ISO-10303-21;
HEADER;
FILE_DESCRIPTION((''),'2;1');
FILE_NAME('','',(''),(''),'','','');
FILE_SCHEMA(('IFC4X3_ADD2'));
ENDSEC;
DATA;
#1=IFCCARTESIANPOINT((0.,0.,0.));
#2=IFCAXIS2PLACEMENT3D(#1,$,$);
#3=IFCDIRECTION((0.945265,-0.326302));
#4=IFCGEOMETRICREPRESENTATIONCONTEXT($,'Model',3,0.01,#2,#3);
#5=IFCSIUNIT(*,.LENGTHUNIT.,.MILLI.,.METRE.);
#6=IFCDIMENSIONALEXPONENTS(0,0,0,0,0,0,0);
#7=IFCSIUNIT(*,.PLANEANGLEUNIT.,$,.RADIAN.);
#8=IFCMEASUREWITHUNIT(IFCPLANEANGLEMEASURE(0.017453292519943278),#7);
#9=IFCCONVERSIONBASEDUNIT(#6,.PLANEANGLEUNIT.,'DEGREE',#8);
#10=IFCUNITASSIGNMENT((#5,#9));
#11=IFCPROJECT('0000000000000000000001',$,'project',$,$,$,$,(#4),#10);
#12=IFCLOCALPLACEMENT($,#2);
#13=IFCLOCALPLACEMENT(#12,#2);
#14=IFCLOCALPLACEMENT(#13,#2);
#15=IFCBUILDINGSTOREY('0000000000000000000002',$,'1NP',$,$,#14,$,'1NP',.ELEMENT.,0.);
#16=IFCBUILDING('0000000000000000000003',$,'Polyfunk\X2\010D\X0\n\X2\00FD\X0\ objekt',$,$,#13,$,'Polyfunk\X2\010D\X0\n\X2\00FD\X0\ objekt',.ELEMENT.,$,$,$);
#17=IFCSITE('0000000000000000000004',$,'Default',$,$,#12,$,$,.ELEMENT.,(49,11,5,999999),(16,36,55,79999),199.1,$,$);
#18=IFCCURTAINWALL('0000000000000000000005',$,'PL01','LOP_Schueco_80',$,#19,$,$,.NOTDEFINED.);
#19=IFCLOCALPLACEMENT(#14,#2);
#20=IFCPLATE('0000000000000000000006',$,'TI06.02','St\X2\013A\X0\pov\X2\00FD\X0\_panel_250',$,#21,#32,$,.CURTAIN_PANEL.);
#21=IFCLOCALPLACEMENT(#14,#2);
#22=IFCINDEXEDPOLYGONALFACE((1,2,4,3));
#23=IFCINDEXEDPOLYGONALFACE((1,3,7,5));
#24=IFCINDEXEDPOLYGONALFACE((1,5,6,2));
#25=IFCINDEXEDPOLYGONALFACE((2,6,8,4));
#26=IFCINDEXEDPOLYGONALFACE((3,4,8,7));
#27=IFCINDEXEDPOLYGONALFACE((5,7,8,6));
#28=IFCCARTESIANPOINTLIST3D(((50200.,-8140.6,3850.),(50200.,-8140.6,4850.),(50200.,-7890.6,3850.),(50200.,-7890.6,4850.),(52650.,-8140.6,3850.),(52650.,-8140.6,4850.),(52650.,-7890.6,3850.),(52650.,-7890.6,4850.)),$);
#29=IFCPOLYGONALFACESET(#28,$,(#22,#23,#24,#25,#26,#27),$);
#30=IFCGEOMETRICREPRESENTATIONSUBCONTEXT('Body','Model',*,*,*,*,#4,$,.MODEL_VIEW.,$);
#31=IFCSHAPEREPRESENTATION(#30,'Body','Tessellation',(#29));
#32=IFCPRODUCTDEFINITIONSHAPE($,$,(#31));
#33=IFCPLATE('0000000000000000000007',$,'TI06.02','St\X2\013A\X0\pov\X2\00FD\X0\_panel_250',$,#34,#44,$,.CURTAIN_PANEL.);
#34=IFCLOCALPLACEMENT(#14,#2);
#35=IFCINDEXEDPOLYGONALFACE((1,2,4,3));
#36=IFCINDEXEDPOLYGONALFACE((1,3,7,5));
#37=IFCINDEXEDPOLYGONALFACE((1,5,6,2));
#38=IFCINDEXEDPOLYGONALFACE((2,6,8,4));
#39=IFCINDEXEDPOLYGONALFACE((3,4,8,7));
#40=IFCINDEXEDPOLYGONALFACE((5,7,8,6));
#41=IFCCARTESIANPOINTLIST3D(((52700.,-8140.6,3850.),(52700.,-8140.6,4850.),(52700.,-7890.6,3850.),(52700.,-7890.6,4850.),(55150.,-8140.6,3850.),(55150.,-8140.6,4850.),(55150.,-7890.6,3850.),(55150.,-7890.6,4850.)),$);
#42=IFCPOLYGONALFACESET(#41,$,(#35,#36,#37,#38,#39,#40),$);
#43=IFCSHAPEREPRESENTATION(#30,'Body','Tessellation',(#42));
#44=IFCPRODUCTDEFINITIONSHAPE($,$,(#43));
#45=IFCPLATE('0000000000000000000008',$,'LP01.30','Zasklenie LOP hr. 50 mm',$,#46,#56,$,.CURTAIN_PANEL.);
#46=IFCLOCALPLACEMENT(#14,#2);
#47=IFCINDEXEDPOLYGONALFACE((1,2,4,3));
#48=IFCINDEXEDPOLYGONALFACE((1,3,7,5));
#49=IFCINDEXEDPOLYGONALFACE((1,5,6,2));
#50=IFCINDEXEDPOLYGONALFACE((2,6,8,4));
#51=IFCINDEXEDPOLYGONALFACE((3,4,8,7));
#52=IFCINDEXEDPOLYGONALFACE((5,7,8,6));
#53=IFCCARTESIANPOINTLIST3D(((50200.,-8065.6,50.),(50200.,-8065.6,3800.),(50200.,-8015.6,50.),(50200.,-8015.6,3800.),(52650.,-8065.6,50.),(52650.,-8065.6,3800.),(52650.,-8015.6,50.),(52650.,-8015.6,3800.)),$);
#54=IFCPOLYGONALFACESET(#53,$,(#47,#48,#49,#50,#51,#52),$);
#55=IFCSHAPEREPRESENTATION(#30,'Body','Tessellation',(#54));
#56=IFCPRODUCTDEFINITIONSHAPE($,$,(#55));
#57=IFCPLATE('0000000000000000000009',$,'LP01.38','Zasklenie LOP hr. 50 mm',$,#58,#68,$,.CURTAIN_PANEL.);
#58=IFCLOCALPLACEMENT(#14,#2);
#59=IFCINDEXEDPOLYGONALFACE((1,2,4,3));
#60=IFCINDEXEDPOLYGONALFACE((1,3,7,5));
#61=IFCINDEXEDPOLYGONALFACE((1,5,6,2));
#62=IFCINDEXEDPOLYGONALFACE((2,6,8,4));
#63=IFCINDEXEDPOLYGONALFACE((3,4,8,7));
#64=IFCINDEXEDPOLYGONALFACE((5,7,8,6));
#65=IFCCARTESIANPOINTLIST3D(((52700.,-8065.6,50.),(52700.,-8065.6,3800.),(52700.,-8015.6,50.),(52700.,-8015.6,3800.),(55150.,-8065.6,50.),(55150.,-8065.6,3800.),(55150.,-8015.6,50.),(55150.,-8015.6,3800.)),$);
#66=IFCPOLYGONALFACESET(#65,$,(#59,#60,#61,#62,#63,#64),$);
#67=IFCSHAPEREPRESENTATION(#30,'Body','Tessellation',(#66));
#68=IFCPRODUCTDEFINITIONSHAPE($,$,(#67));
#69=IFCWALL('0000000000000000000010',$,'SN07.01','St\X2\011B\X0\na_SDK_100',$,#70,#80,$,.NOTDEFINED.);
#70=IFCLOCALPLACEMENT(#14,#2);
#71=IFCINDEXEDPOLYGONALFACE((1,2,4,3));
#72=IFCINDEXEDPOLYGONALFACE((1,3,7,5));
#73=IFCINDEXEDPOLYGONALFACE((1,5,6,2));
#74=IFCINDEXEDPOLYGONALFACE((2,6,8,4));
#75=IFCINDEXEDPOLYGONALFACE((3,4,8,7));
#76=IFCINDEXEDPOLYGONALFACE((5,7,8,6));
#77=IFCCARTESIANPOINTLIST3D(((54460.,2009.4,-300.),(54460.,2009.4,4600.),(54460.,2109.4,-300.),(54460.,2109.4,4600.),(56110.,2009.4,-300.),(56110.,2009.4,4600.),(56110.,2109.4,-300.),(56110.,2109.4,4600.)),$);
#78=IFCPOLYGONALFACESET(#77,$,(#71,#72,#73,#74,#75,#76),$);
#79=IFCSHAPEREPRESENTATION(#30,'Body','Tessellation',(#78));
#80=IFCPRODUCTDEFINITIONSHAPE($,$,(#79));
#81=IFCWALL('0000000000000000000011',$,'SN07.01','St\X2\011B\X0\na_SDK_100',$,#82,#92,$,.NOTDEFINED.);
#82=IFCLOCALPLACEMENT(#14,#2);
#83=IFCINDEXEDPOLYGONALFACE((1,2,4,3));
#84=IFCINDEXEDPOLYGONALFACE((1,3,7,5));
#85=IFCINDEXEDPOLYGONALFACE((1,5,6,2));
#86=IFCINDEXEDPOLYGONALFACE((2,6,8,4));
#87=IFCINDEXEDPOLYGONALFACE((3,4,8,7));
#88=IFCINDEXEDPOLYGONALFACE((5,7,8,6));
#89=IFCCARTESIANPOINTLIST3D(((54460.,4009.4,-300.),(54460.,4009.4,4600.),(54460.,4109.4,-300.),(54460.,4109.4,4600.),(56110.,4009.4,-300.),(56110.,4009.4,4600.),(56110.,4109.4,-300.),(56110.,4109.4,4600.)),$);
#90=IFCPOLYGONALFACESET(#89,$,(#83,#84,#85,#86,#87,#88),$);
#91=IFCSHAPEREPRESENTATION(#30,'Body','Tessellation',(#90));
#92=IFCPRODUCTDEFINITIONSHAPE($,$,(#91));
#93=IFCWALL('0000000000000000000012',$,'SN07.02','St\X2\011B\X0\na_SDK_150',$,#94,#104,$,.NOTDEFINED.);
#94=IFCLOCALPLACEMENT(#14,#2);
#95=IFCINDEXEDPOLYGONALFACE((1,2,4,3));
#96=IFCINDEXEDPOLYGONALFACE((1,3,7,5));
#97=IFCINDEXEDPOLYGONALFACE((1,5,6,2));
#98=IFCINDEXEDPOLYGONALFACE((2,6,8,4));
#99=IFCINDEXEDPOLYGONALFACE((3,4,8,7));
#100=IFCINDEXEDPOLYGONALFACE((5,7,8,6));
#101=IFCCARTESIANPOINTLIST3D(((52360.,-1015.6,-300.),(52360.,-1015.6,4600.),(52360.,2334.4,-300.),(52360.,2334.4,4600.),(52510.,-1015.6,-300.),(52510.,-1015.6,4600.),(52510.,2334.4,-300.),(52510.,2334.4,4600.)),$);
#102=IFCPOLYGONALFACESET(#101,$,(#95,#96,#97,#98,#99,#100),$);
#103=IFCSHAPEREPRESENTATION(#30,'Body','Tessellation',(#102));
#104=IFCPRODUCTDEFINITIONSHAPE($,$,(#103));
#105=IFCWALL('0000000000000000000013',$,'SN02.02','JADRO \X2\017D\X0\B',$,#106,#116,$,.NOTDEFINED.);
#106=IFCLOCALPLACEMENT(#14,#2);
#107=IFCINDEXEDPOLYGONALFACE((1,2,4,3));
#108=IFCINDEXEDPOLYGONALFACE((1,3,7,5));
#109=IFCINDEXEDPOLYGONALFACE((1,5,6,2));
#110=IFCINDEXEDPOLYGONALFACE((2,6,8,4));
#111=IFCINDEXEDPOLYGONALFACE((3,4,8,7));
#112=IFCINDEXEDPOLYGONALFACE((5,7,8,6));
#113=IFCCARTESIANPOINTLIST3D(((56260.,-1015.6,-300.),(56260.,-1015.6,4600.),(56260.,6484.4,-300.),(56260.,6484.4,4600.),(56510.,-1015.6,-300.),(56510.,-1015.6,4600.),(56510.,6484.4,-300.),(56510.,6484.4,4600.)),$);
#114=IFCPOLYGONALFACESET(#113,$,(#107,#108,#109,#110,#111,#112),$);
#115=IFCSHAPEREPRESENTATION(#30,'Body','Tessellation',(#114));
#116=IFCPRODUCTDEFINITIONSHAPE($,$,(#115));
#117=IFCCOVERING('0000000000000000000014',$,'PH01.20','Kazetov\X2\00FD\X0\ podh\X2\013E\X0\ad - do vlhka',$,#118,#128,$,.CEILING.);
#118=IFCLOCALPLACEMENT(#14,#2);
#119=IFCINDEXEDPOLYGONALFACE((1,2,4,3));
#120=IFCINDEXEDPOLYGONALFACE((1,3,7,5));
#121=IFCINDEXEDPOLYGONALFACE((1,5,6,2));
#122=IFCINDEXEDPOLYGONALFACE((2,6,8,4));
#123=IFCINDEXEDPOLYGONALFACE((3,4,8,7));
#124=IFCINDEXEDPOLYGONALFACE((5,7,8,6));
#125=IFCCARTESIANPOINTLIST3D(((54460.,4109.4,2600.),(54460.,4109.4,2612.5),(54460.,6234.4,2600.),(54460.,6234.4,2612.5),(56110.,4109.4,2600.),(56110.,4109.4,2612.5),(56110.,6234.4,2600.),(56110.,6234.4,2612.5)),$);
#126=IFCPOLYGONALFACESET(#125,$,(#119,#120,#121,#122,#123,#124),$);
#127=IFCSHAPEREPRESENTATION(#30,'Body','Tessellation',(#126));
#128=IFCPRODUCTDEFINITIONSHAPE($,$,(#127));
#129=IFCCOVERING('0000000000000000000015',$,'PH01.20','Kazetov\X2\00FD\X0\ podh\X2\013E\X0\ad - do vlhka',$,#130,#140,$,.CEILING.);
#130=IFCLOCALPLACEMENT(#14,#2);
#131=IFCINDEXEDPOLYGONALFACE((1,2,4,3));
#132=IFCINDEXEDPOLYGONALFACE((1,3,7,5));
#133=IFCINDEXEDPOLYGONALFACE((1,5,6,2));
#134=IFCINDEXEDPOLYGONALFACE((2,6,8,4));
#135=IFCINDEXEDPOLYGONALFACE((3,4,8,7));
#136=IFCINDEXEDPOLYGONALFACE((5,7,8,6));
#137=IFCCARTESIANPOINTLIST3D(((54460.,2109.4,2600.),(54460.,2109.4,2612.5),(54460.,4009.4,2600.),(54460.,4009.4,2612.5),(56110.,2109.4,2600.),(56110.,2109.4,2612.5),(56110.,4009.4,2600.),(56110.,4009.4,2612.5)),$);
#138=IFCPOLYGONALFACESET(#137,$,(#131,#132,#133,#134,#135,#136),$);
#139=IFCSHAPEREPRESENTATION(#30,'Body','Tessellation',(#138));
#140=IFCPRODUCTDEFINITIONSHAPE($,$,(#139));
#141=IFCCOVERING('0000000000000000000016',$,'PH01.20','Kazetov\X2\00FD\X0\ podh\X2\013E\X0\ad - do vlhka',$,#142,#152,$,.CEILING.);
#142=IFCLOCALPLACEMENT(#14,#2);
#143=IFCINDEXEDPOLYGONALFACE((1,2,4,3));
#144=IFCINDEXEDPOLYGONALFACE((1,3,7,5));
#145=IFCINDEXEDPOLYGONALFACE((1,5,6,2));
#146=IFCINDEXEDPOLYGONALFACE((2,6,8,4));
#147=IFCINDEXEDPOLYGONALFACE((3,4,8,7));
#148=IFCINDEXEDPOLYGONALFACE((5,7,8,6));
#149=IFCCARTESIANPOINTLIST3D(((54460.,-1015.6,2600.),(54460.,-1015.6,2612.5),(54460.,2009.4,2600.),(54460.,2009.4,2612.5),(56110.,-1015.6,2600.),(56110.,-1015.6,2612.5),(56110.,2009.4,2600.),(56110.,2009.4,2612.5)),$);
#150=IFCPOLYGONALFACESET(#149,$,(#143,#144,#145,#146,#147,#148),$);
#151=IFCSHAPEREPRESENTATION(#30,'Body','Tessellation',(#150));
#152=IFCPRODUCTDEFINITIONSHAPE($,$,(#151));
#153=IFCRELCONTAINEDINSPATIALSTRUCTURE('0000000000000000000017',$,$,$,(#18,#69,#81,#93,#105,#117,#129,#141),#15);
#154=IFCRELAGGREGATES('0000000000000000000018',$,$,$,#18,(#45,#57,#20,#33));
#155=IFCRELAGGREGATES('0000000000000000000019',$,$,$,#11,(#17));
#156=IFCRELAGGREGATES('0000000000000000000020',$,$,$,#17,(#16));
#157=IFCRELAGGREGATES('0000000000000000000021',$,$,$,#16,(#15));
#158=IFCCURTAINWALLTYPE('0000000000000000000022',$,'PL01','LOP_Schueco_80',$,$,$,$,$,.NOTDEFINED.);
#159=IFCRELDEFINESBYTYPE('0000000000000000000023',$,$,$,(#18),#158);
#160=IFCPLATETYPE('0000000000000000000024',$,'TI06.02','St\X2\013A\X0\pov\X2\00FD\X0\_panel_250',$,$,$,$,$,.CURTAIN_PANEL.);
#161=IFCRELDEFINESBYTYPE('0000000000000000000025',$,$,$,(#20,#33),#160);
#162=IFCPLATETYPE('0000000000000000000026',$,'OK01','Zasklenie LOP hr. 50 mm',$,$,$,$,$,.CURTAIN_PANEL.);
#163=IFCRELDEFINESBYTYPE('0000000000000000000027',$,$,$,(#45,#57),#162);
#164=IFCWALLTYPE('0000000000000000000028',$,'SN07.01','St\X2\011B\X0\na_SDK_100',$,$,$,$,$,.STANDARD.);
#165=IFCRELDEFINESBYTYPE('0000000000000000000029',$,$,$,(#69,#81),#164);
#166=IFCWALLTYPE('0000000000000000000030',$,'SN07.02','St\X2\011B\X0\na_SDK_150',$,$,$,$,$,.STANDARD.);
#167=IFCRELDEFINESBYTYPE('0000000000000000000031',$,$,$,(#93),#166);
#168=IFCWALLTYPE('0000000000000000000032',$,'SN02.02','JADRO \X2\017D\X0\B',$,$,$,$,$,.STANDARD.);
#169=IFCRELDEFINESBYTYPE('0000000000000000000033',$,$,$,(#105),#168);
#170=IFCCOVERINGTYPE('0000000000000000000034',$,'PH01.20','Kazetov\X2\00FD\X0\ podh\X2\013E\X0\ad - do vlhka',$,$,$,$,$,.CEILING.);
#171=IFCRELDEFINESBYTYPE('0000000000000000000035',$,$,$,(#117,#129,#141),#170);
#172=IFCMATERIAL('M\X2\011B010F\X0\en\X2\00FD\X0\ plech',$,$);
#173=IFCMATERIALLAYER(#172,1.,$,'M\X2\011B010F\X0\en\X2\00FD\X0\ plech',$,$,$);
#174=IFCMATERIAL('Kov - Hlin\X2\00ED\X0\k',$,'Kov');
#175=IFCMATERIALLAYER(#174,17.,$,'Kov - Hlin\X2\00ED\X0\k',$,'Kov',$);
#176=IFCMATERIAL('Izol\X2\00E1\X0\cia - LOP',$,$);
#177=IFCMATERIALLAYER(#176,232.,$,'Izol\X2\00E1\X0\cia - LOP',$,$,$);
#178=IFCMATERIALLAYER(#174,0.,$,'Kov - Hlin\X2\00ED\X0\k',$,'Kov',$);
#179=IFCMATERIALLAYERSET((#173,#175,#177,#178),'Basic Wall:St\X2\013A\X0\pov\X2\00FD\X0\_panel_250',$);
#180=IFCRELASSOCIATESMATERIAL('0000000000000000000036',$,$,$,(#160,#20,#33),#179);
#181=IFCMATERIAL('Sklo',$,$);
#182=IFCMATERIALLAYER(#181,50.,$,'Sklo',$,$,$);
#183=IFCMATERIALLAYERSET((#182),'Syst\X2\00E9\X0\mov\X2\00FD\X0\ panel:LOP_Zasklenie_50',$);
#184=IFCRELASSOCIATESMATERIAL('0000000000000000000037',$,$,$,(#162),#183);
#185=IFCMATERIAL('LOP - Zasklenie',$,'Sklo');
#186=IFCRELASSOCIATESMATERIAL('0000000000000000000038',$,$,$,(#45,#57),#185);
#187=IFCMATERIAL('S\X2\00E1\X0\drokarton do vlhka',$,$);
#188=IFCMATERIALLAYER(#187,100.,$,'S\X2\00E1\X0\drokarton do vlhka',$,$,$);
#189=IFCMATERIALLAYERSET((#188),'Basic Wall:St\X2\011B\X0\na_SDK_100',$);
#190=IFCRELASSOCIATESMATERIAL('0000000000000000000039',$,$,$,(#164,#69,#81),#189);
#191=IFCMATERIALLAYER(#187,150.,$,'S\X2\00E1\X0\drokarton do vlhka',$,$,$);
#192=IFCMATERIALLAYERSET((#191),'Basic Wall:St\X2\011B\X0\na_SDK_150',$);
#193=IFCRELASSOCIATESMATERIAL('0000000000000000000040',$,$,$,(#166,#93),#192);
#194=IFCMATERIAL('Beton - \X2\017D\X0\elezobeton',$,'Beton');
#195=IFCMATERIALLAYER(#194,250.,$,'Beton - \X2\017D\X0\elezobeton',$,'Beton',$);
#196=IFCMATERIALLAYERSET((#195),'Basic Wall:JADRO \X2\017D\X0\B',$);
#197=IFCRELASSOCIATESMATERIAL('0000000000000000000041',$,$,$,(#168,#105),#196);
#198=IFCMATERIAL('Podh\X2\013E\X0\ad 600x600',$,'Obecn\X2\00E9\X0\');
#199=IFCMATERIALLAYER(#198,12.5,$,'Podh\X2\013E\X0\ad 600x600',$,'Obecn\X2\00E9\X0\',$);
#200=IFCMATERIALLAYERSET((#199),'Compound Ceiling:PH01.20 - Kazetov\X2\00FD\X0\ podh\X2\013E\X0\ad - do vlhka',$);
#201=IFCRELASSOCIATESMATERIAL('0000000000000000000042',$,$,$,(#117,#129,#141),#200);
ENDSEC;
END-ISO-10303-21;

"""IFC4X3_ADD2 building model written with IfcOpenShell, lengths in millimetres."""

from ifc_helpers import new_model, entity, si_unit, converted_unit, direction, frame, frame_2d, origin, origin_2d_with_axis, place, context, subcontext, project, spatial, polyline, rectangle, extrude, clip, bounded_halfspace, source, transform, mapped, material, layer, layer_set, layer_usage, type_object, type_shapes, element, aggregate, save


model = new_model("IFC4X3_ADD2")

# Units and contexts
model_context = context("Model", 3, precision=0.01, world=origin(), true_north=direction((0.945265, -0.326302)))
body_context = subcontext(model_context, "Body", "Model", "MODEL_VIEW")
ifc_project = project(units=[si_unit("LENGTHUNIT", "METRE", prefix="MILLI"), converted_unit("PLANEANGLEUNIT", "DEGREE", entity("IfcPlaneAngleMeasure", 0.017453292519943278), si_unit("PLANEANGLEUNIT", "RADIAN"), dimensions=[0, 0, 0, 0, 0, 0, 0])], contexts=[model_context])

# Site, building, storey
site_placement = place(None, origin())
site = spatial("IfcSite", under=ifc_project, at=site_placement, Name="Default", CompositionType="ELEMENT", RefLatitude=(49, 11, 5, 999999), RefLongitude=(16, 36, 55, 79999), RefElevation=199.1)
building_placement = place(site_placement, origin())
building = spatial("IfcBuilding", under=site, at=building_placement, Name="Polyfunkčný objekt", LongName="Polyfunkčný objekt", CompositionType="ELEMENT")
storey_placement = place(building_placement, origin())
storey = spatial("IfcBuildingStorey", under=building, at=storey_placement, Name="1NP", LongName="1NP", CompositionType="ELEMENT", Elevation=0.0)

# Curtain wall, plates
curtain_wall_type = type_object("IfcCurtainWallType", Name="PL01", Description="LOP_Schueco_80", PredefinedType="NOTDEFINED")
curtain_wall_placement = place(storey_placement, origin())
curtain_wall = element("IfcCurtainWall", 1, at=curtain_wall_placement, inside=storey, type_object=curtain_wall_type, Name="PL01", Description="LOP_Schueco_80", PredefinedType="NOTDEFINED")
ifc_material_1 = material(Name="Měďený plech")
ifc_layer_1 = layer(ifc_material_1, 1.0, Name="Měďený plech")
ifc_material_2 = material(Name="Kov - Hliník", Category="Kov")
ifc_layer_2 = layer(ifc_material_2, 17.0, Name="Kov - Hliník", Category="Kov")
ifc_material_3 = material(Name="Izolácia - LOP")
ifc_layer_3 = layer(ifc_material_3, 232.0, Name="Izolácia - LOP")
ifc_layer_4 = layer(ifc_material_2, 0.0, Name="Kov - Hliník", Category="Kov")
ifc_layer_set_1 = layer_set([ifc_layer_1, ifc_layer_2, ifc_layer_3, ifc_layer_4], Name="Basic Wall:Stĺpový_panel_250")
ifc_layer_usage_1 = layer_usage(ifc_layer_set_1, "AXIS2", "POSITIVE", -125.0)
plate_type_1 = type_object("IfcPlateType", Name="TI06.02", Description="Stĺpový_panel_250", PredefinedType="CURTAIN_PANEL", material=ifc_layer_set_1)
plate_1_placement = place(storey_placement, frame((50200.0, -8015.6, 3850.0)))
plate_1 = element("IfcPlate", 2, at=plate_1_placement, type_object=plate_type_1, material=ifc_layer_usage_1, Name="TI06.02", Description="Stĺpový_panel_250", PredefinedType="CURTAIN_PANEL", context=body_context, shape_type="SweptSolid", body=[
    extrude(rectangle(XDim=250.0, YDim=2450.0, at=origin_2d_with_axis()), frame((1225.0, 0.0, 0.0), z_axis=(0.0, 0.0, 1.0), x_axis=(0.0, 1.0, 0.0)), (0.0, 0.0, 1.0), 1000.0),
])
ifc_layer_usage_2 = layer_usage(ifc_layer_set_1, "AXIS2", "POSITIVE", -125.0)
plate_2_placement = place(storey_placement, frame((52700.0, -8015.6, 3850.0)))
plate_2 = element("IfcPlate", 3, at=plate_2_placement, type_object=plate_type_1, material=ifc_layer_usage_2, Name="TI06.02", Description="Stĺpový_panel_250", PredefinedType="CURTAIN_PANEL", context=body_context, shape_type="SweptSolid", body=[
    extrude(rectangle(XDim=250.0, YDim=2450.0, at=frame_2d((0.0, 0.0), x_axis=(1.0, 0.0))), frame((1225.0, 0.0, 0.0), z_axis=(0.0, 0.0, 1.0), x_axis=(0.0, 1.0, 0.0)), (0.0, 0.0, 1.0), 1000.0),
])
ifc_material_4 = material(Name="LOP - Zasklenie", Category="Sklo")
ifc_material_5 = material(Name="Sklo")
ifc_layer_5 = layer(ifc_material_5, 50.0, Name="Sklo")
ifc_layer_set_2 = layer_set([ifc_layer_5], Name="Systémový panel:LOP_Zasklenie_50")
plate_type_2 = type_object("IfcPlateType", Name="OK01", Description="Zasklenie LOP hr. 50 mm", PredefinedType="CURTAIN_PANEL", material=ifc_layer_set_2)
shared_shape_1 = source(origin(), body_context, "Body", "SweptSolid", [
    extrude(rectangle(XDim=3750.0, YDim=2450.0, at=frame_2d((-331.2, 0.0), x_axis=(1.0, 0.0))), frame((0.0, -50.0, 2206.2), z_axis=(0.0, 1.0, 0.0), x_axis=(0.0, 0.0, 1.0)), (0.0, 0.0, 1.0), 50.0),
])
type_shapes(plate_type_2, [shared_shape_1])
plate_3_placement = place(curtain_wall_placement, frame((51425.0, -8015.6, 50.0)))
plate_3 = element("IfcPlate", 4, at=plate_3_placement, type_object=plate_type_2, material=ifc_material_4, Name="LP01.30", Description="Zasklenie LOP hr. 50 mm", PredefinedType="CURTAIN_PANEL", context=body_context, shape_type="MappedRepresentation", body=[
    mapped(shared_shape_1, transform((0.0, 0.0, 0.0), scale=1.0)),
])
plate_4_placement = place(curtain_wall_placement, frame((53925.0, -8015.6, 50.0)))
plate_4 = element("IfcPlate", 5, at=plate_4_placement, type_object=plate_type_2, material=ifc_material_4, Name="LP01.38", Description="Zasklenie LOP hr. 50 mm", PredefinedType="CURTAIN_PANEL", context=body_context, shape_type="MappedRepresentation", body=[
    mapped(shared_shape_1, transform((0.0, 0.0, 0.0), scale=1.0)),
])
aggregate(curtain_wall, [plate_3, plate_4, plate_1, plate_2])

# Walls
ifc_material_6 = material(Name="Sádrokarton do vlhka")
ifc_layer_6 = layer(ifc_material_6, 100.0, Name="Sádrokarton do vlhka")
ifc_layer_set_3 = layer_set([ifc_layer_6], Name="Basic Wall:Stěna_SDK_100")
wall_type_1 = type_object("IfcWallType", Name="SN07.01", Description="Stěna_SDK_100", PredefinedType="STANDARD", material=ifc_layer_set_3)
wall_1_placement = place(storey_placement, frame((54460.0, 2059.4, -300.0)))
element("IfcWall", 6, at=wall_1_placement, inside=storey, type_object=wall_type_1, material=ifc_layer_set_3, Name="SN07.01", Description="Stěna_SDK_100", PredefinedType="NOTDEFINED", context=body_context, shape_type="Clipping", body=[
    clip(clip(extrude(rectangle(XDim=1650.0, YDim=100.0, at=frame_2d((825.0, 0.0), x_axis=(-1.0, 0.0))), origin(), (0.0, 0.0, 1.0), 4900.0), bounded_halfspace(frame((0.0, -50.0, 4900.0), z_axis=(0.0, 0.0, -1.0), x_axis=(1.0, 0.0, 0.0)), True, frame((0.0, -50.0, 4900.0)), polyline([(0.0, 0.0), (1650.0, 0.0), (1650.0, 100.0), (0.0, 100.0), (0.0, 0.0)]))), bounded_halfspace(frame((1650.0, -50.0, 0.0), z_axis=(0.0, 0.0, 1.0), x_axis=(0.0, 1.0, 0.0)), True, frame((1650.0, -50.0, 0.0)), polyline([(0.0, 0.0), (0.0, 100.0), (-1650.0, 100.0), (-1650.0, 0.0), (0.0, 0.0)]))),
])
wall_2_placement = place(storey_placement, frame((54460.0, 4059.4, -300.0)))
element("IfcWall", 7, at=wall_2_placement, inside=storey, type_object=wall_type_1, material=ifc_layer_set_3, Name="SN07.01", Description="Stěna_SDK_100", PredefinedType="NOTDEFINED", context=body_context, shape_type="Clipping", body=[
    clip(clip(extrude(rectangle(XDim=1650.0, YDim=100.0, at=frame_2d((825.0, 0.0), x_axis=(-1.0, 0.0))), origin(), (0.0, 0.0, 1.0), 4900.0), bounded_halfspace(frame((0.0, -50.0, 4900.0), z_axis=(0.0, 0.0, -1.0), x_axis=(1.0, 0.0, 0.0)), True, frame((0.0, -50.0, 4900.0)), polyline([(0.0, 0.0), (1650.0, 0.0), (1650.0, 100.0), (0.0, 100.0), (0.0, 0.0)]))), bounded_halfspace(frame((1650.0, -50.0, 0.0), z_axis=(0.0, 0.0, 1.0), x_axis=(0.0, 1.0, 0.0)), True, frame((1650.0, -50.0, 0.0)), polyline([(0.0, 0.0), (0.0, 100.0), (-1650.0, 100.0), (-1650.0, 0.0), (0.0, 0.0)]))),
])
ifc_layer_7 = layer(ifc_material_6, 150.0, Name="Sádrokarton do vlhka")
ifc_layer_set_4 = layer_set([ifc_layer_7], Name="Basic Wall:Stěna_SDK_150")
wall_type_2 = type_object("IfcWallType", Name="SN07.02", Description="Stěna_SDK_150", PredefinedType="STANDARD", material=ifc_layer_set_4)
wall_3_placement = place(storey_placement, frame((52435.0, 2334.4, -300.0), z_axis=(0.0, 0.0, 1.0), x_axis=(0.0, -1.0, 0.0)))
element("IfcWall", 8, at=wall_3_placement, inside=storey, type_object=wall_type_2, material=ifc_layer_set_4, Name="SN07.02", Description="Stěna_SDK_150", PredefinedType="NOTDEFINED", context=body_context, shape_type="Clipping", body=[
    clip(clip(extrude(rectangle(XDim=3350.0, YDim=150.0, at=frame_2d((1675.0, 0.0), x_axis=(-1.0, 0.0))), origin(), (0.0, 0.0, 1.0), 4900.0), bounded_halfspace(frame((3350.0, -75.0, 0.0), z_axis=(0.0, 0.0, 1.0), x_axis=(-1.0, 0.0, 0.0)), True, frame((3350.0, -75.0, 0.0)), polyline([(0.0, 0.0), (0.0, 150.0), (-3350.0, 150.0), (-3350.0, 0.0), (0.0, 0.0)]))), bounded_halfspace(frame((0.0, -75.0, 4900.0), z_axis=(0.0, 0.0, -1.0), x_axis=(0.0, 1.0, 0.0)), True, frame((0.0, -75.0, 4900.0)), polyline([(0.0, 0.0), (3350.0, 0.0), (3350.0, 150.0), (0.0, 150.0), (0.0, 0.0)]))),
])
ifc_material_7 = material(Name="Beton - Železobeton", Category="Beton")
ifc_layer_8 = layer(ifc_material_7, 250.0, Name="Beton - Železobeton", Category="Beton")
ifc_layer_set_5 = layer_set([ifc_layer_8], Name="Basic Wall:JADRO ŽB")
wall_type_3 = type_object("IfcWallType", Name="SN02.02", Description="JADRO ŽB", PredefinedType="STANDARD", material=ifc_layer_set_5)
wall_4_placement = place(storey_placement, frame((56385.0, -1015.6, -300.0), z_axis=(0.0, 0.0, 1.0), x_axis=(0.0, 1.0, 0.0)))
element("IfcWall", 9, at=wall_4_placement, inside=storey, type_object=wall_type_3, material=ifc_layer_set_5, Name="SN02.02", Description="JADRO ŽB", PredefinedType="NOTDEFINED", context=body_context, shape_type="Clipping", body=[
    clip(clip(extrude(rectangle(XDim=7500.0, YDim=250.0, at=frame_2d((3750.0, 0.0), x_axis=(-1.0, 0.0))), origin(), (0.0, 0.0, 1.0), 4900.0), bounded_halfspace(frame((0.0, -125.0, 4900.0), z_axis=(0.0, 0.0, -1.0), x_axis=(0.0, -1.0, 0.0)), True, frame((0.0, -125.0, 4900.0)), polyline([(0.0, 0.0), (7500.0, 0.0), (7500.0, 250.0), (7250.0, 250.0), (0.0, 250.0), (0.0, 0.0)]))), bounded_halfspace(frame((0.0, -125.0, 0.0)), True, frame((0.0, -125.0, 0.0)), polyline([(0.0, 0.0), (7110.0, 0.0), (7500.0, 0.0), (7500.0, 250.0), (7250.0, 250.0), (0.0, 250.0), (0.0, 0.0)]))),
])

# Shared definitions
ifc_material_8 = material(Name="Podhľad 600x600", Category="Obecné")

# Coverings
ifc_layer_9 = layer(ifc_material_8, 12.5, Name="Podhľad 600x600", Category="Obecné")
ifc_layer_set_6 = layer_set([ifc_layer_9], Name="Compound Ceiling:PH01.20 - Kazetový podhľad - do vlhka")
ifc_layer_usage_3 = layer_usage(ifc_layer_set_6, "AXIS3", "NEGATIVE", 0.0)
covering_type_1 = type_object("IfcCoveringType", Name="PH01.20", Description="Kazetový podhľad - do vlhka", PredefinedType="CEILING")
covering_1_placement = place(storey_placement, frame((54460.0, 4109.4, 2600.0)))
element("IfcCovering", 10, at=covering_1_placement, inside=storey, type_object=covering_type_1, material=ifc_layer_usage_3, Name="PH01.20", Description="Kazetový podhľad - do vlhka", PredefinedType="CEILING", context=body_context, shape_type="SweptSolid", body=[
    extrude(rectangle(XDim=2125.0, YDim=1650.0, at=frame_2d((0.0, 0.0), x_axis=(1.0, 0.0))), frame((825.0, 1062.5, 0.0), z_axis=(0.0, 0.0, 1.0), x_axis=(0.0, -1.0, 0.0)), (0.0, 0.0, 1.0), 12.5),
])
ifc_layer_usage_4 = layer_usage(ifc_layer_set_6, "AXIS3", "NEGATIVE", 0.0)
covering_2_placement = place(storey_placement, frame((54460.0, 2109.4, 2600.0)))
element("IfcCovering", 11, at=covering_2_placement, inside=storey, type_object=covering_type_1, material=ifc_layer_usage_4, Name="PH01.20", Description="Kazetový podhľad - do vlhka", PredefinedType="CEILING", context=body_context, shape_type="SweptSolid", body=[
    extrude(rectangle(XDim=1900.0, YDim=1650.0, at=frame_2d((0.0, 0.0), x_axis=(1.0, 0.0))), frame((825.0, 950.0, 0.0), z_axis=(0.0, 0.0, 1.0), x_axis=(0.0, 1.0, 0.0)), (0.0, 0.0, 1.0), 12.5),
])
ifc_layer_usage_5 = layer_usage(ifc_layer_set_6, "AXIS3", "NEGATIVE", 0.0)
covering_3_placement = place(storey_placement, frame((54460.0, -1015.6, 2600.0)))
element("IfcCovering", 12, at=covering_3_placement, inside=storey, type_object=covering_type_1, material=ifc_layer_usage_5, Name="PH01.20", Description="Kazetový podhľad - do vlhka", PredefinedType="CEILING", context=body_context, shape_type="SweptSolid", body=[
    extrude(rectangle(XDim=1650.0, YDim=3025.0, at=frame_2d((0.0, 0.0), x_axis=(1.0, 0.0))), frame((825.0, 1512.5, 0.0), z_axis=(0.0, 0.0, 1.0), x_axis=(-1.0, 0.0, 0.0)), (0.0, 0.0, 1.0), 12.5),
])

save(model, "model.ifc")
